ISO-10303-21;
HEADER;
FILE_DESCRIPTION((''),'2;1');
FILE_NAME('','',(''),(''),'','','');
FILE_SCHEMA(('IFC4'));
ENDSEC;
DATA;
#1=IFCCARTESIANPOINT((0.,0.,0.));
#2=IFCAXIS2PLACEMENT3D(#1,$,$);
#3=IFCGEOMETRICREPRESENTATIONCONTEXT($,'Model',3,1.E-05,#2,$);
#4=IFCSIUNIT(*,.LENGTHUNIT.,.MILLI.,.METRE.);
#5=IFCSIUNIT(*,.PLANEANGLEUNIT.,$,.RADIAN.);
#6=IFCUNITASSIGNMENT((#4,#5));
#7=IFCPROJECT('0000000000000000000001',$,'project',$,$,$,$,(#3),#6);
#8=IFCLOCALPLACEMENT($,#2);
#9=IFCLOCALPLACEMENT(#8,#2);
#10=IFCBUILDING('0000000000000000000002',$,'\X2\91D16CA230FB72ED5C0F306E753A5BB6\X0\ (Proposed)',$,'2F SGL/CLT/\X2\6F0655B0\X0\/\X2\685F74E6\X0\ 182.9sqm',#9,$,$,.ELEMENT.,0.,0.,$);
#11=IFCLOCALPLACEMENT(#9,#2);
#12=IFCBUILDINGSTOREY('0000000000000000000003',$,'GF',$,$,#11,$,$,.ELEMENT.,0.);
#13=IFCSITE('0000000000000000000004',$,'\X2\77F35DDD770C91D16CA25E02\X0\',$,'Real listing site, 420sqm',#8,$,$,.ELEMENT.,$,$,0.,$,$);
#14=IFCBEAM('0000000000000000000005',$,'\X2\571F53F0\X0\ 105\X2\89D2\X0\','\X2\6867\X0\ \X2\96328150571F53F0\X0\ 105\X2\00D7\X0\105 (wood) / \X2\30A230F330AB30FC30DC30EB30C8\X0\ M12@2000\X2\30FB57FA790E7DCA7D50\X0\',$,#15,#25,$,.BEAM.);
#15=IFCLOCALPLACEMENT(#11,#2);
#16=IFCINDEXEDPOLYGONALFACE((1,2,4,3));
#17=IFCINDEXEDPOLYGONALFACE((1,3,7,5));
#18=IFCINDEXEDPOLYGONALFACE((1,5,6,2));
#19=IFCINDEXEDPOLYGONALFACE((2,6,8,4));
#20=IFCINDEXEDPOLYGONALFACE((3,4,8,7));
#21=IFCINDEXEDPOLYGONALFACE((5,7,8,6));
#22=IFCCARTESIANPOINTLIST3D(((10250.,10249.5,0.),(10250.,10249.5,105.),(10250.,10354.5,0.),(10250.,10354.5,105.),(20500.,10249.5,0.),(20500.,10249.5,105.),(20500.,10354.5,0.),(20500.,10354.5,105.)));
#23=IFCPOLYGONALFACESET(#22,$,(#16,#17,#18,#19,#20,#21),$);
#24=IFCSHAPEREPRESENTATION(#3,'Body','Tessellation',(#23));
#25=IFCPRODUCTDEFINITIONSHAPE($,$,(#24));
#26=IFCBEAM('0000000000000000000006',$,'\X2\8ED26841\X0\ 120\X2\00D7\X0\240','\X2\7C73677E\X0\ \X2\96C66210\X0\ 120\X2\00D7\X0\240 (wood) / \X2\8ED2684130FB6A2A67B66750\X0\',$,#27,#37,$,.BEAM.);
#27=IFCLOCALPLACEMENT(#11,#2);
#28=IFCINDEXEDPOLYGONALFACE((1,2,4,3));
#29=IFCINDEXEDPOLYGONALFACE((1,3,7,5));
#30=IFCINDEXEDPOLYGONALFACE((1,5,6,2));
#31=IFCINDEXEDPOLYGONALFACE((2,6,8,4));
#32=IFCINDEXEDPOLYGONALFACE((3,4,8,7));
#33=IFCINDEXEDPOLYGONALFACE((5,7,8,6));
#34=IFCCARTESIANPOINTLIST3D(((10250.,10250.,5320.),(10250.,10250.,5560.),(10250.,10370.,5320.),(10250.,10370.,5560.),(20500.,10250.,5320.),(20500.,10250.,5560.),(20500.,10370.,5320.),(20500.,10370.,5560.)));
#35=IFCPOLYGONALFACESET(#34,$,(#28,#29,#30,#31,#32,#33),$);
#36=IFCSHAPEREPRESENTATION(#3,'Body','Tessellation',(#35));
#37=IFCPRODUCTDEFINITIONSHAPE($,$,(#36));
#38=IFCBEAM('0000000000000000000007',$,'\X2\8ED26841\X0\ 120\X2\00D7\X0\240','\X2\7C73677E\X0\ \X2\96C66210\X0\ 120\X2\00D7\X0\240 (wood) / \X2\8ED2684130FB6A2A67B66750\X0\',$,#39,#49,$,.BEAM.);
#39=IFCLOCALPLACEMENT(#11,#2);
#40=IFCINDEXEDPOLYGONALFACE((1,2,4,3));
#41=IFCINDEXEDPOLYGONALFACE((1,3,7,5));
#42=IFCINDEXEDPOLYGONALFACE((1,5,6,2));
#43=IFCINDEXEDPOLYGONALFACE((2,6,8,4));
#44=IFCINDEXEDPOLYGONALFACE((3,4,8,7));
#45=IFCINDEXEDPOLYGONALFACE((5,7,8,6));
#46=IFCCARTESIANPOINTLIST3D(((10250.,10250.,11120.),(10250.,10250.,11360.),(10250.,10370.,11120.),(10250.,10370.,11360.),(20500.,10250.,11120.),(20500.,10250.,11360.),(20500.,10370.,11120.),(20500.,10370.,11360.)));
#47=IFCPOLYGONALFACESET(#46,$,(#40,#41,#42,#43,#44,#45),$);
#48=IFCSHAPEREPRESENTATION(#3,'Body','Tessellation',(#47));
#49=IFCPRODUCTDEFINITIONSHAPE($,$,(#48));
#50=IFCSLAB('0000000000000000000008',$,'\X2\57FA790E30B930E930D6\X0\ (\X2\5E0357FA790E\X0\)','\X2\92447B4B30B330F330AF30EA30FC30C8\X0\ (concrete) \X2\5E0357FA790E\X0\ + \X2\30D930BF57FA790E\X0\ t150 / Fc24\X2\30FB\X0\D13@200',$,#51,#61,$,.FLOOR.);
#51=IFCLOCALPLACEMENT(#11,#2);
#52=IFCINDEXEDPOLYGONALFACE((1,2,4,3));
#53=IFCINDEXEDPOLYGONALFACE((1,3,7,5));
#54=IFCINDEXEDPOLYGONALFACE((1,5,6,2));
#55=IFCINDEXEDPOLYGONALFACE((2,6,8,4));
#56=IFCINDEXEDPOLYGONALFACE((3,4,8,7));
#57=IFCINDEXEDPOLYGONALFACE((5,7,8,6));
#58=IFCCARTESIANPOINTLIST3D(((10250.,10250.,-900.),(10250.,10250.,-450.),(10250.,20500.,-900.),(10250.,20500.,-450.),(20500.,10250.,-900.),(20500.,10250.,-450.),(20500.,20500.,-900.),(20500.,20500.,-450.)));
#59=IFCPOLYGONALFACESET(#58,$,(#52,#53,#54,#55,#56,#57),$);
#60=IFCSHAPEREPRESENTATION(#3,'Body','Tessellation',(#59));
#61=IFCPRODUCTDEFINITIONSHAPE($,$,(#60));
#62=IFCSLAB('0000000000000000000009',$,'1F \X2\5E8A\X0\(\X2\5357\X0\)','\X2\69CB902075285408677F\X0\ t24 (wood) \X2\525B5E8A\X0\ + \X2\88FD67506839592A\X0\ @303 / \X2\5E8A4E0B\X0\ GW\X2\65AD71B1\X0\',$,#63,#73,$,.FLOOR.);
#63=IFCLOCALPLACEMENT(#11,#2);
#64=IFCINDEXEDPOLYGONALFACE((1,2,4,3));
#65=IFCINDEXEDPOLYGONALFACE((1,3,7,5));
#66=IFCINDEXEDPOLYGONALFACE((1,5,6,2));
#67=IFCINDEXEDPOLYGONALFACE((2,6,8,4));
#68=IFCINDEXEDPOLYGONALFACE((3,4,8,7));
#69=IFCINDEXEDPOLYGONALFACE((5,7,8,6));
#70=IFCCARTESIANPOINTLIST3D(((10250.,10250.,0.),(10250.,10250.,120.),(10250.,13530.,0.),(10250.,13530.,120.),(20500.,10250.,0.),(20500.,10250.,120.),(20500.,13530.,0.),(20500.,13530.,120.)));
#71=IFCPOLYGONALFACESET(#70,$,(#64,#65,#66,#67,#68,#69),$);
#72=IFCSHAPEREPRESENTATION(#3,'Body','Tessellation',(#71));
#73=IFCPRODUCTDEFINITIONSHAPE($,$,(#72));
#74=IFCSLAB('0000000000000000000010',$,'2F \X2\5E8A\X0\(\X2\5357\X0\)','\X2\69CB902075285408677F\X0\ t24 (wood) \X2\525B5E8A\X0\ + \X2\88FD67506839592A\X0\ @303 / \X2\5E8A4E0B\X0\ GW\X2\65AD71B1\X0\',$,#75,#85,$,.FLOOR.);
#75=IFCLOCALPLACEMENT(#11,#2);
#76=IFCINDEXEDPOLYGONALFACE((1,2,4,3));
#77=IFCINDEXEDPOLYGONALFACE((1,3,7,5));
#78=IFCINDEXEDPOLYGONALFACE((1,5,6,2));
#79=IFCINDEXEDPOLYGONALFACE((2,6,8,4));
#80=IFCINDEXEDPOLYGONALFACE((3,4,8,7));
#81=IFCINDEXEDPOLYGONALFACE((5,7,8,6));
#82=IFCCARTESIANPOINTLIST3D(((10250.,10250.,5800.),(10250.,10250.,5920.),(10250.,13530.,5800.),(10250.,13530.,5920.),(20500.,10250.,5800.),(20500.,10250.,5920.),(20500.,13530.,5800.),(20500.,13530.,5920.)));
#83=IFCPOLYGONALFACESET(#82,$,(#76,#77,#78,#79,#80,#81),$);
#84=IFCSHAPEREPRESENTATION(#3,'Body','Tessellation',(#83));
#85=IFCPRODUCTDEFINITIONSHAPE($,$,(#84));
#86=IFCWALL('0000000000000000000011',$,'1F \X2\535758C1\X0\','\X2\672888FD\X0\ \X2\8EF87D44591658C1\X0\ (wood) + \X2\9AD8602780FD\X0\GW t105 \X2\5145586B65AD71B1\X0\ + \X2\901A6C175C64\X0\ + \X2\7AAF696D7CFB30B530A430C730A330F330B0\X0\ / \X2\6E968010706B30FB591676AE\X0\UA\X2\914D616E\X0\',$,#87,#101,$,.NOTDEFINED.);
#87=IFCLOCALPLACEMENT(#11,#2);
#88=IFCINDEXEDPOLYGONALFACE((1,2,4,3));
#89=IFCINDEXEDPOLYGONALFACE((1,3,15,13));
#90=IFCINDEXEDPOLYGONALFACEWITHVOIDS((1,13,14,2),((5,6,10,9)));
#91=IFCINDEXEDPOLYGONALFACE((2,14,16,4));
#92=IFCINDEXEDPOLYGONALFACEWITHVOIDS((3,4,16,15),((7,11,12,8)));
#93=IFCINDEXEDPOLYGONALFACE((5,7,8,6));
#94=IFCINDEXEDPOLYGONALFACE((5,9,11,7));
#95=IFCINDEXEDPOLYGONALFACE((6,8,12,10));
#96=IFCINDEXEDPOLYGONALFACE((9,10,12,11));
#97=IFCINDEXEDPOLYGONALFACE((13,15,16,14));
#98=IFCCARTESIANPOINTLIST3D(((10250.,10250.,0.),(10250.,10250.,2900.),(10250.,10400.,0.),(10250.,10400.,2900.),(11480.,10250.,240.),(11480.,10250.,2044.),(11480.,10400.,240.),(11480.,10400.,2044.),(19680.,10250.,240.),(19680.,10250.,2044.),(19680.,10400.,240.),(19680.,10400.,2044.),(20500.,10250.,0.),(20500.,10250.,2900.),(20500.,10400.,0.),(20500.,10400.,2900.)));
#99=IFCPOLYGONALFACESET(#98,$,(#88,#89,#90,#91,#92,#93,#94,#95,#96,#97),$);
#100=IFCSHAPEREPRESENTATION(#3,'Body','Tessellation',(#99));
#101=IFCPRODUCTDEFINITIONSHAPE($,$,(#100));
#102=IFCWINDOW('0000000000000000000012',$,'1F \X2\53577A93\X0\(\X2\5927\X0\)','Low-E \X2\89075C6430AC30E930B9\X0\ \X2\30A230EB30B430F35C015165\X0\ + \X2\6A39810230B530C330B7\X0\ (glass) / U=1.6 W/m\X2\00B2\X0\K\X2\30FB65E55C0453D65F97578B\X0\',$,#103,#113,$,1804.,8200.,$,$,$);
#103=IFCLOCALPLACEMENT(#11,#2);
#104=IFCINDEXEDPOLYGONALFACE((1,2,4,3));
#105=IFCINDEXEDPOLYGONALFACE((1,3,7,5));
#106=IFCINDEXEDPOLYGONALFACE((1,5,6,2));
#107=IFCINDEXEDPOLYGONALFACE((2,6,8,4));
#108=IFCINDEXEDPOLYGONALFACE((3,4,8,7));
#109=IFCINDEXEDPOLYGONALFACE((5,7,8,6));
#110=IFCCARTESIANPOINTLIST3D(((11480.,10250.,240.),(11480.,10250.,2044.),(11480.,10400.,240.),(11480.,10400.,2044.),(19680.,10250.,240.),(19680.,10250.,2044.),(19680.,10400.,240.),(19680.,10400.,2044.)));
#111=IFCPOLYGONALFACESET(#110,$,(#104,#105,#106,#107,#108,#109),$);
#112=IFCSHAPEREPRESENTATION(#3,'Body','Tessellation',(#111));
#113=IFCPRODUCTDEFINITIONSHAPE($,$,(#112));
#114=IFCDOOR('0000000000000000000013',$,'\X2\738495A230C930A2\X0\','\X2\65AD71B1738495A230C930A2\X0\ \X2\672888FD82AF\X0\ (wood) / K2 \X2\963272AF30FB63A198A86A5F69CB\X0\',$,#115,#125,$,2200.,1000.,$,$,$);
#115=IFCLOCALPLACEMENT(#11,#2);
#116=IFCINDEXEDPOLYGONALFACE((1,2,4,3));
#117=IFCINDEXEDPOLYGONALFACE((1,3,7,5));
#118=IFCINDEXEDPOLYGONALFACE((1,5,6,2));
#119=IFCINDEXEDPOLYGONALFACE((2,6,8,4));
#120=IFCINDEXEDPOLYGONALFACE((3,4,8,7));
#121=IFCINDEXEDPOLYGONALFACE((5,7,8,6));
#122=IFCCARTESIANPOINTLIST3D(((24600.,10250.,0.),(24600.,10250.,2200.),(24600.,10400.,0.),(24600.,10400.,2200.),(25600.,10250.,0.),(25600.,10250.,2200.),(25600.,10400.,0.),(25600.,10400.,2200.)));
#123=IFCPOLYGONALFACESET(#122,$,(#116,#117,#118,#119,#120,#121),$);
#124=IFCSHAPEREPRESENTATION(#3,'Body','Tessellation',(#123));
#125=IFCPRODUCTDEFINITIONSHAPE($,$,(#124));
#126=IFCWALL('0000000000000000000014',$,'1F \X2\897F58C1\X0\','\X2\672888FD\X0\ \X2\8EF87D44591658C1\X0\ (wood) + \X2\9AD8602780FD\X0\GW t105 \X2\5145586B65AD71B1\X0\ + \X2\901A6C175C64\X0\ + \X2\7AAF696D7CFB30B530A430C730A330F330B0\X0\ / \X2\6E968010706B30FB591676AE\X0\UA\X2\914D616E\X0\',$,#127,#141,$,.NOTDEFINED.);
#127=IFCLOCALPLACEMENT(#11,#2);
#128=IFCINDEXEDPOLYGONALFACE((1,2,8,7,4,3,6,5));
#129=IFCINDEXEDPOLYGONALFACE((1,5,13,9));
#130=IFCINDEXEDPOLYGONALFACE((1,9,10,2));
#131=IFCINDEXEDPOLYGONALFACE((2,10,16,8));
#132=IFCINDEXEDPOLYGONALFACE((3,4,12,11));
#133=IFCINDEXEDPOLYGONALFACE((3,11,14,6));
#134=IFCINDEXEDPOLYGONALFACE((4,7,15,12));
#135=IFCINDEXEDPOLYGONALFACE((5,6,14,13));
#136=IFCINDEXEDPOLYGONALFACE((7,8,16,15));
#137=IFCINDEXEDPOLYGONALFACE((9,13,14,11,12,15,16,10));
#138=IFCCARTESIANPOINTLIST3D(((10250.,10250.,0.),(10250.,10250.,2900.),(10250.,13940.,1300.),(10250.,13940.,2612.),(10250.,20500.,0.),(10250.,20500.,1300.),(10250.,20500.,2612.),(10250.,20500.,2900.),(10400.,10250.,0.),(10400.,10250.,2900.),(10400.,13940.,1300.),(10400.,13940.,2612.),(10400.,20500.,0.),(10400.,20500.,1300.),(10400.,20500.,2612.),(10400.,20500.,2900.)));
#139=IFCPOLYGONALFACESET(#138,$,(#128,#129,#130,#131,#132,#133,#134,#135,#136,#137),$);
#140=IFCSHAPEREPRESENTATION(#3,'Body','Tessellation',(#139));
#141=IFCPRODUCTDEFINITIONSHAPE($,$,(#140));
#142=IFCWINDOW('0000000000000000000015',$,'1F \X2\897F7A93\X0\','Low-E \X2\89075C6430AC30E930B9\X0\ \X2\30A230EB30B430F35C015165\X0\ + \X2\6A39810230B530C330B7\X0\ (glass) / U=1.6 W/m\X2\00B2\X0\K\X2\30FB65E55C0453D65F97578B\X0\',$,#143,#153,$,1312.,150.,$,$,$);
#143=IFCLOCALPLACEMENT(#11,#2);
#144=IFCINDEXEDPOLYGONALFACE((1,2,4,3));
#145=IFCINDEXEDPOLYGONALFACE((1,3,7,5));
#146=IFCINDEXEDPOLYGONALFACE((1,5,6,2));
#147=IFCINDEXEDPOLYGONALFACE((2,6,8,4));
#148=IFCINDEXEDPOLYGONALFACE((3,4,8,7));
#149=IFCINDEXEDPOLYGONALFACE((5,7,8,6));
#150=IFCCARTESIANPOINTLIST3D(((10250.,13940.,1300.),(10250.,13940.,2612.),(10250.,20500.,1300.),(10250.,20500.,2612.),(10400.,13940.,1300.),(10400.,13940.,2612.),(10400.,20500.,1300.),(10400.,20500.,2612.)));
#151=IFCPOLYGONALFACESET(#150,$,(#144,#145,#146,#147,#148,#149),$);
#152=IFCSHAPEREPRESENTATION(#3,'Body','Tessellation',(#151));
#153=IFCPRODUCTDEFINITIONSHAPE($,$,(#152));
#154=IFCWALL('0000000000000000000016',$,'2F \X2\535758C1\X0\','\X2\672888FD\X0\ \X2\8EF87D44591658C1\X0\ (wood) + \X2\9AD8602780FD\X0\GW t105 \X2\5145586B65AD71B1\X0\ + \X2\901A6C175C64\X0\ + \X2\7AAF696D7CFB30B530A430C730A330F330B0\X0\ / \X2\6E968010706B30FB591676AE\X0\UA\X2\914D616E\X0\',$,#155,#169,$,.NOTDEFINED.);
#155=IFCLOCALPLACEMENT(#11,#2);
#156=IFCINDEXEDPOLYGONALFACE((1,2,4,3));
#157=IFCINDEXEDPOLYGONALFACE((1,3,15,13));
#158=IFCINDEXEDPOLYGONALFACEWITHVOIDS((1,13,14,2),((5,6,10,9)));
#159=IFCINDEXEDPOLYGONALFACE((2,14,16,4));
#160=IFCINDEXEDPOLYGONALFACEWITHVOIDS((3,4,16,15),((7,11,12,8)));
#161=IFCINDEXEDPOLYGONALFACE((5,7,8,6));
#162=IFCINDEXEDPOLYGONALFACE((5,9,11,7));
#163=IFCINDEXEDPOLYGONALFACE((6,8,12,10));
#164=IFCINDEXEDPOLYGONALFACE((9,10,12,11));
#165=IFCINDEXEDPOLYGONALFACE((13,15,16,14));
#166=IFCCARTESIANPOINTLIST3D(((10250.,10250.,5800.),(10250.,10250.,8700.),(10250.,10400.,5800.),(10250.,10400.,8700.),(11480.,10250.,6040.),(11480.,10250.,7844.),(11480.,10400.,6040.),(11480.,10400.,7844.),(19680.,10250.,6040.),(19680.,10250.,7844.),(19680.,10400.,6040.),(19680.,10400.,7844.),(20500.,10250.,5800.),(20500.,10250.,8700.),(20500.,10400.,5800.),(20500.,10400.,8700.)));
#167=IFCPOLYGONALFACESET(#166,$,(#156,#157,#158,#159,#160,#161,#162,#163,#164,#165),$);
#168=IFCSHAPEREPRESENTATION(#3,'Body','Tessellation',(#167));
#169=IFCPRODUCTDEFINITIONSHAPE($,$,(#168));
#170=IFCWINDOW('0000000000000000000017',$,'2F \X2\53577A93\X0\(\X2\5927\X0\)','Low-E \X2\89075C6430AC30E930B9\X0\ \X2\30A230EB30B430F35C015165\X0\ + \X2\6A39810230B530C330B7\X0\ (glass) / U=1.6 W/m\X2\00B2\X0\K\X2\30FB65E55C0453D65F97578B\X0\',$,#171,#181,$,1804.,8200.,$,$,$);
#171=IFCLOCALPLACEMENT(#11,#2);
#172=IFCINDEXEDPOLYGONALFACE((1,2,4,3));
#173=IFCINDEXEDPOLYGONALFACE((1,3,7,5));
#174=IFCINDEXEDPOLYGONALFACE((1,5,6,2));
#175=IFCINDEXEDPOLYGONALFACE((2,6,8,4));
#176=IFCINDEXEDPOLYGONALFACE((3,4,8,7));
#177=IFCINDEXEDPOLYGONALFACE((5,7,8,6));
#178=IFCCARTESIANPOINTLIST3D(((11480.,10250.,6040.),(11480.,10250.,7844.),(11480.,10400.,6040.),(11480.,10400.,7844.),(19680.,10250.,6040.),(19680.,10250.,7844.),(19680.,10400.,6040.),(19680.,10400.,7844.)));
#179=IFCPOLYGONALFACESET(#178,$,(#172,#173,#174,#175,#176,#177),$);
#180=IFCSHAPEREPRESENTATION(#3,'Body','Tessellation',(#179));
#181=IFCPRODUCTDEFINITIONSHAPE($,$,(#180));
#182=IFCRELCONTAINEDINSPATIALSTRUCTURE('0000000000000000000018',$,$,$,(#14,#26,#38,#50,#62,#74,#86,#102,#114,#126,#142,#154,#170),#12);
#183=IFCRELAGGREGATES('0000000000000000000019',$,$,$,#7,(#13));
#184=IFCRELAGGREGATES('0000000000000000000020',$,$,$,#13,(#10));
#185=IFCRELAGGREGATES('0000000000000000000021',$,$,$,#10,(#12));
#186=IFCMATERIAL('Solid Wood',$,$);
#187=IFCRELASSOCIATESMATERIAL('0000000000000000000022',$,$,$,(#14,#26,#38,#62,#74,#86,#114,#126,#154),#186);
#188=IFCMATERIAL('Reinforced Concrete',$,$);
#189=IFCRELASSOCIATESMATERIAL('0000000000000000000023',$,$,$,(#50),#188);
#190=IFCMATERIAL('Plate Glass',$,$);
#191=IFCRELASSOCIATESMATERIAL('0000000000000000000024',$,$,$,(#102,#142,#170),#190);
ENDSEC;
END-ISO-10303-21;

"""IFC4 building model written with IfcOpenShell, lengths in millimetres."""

from ifc_helpers import new_model, si_unit, frame, frame_2d, origin, place, context, project, spatial, rectangle, extrude, material, element, fill, save


model = new_model("IFC4")

# Units and contexts
model_context = context("Model", 3, precision=1e-05, world=origin())
ifc_project = project(units=[si_unit("LENGTHUNIT", "METRE", prefix="MILLI"), si_unit("PLANEANGLEUNIT", "RADIAN")], contexts=[model_context])

# Site, building, storey
site_placement = place(None, origin())
site = spatial("IfcSite", under=ifc_project, at=site_placement, Name="石川県金沢市", ObjectType="Real listing site, 420sqm", CompositionType="ELEMENT", RefElevation=0.0)
building_placement = place(site_placement, origin())
building = spatial("IfcBuilding", under=site, at=building_placement, Name="金沢・狭小の町家 (Proposed)", ObjectType="2F SGL/CLT/漆喰/桟瓦 182.9sqm", CompositionType="ELEMENT", ElevationOfRefHeight=0.0, ElevationOfTerrain=0.0)
storey_placement = place(building_placement, origin())
storey = spatial("IfcBuildingStorey", under=building, at=storey_placement, Name="GF", CompositionType="ELEMENT", Elevation=0.0)

# Shared definitions
ifc_material_1 = material(Name="Solid Wood")

# Beams
beam_1_placement = place(storey_placement, frame((5125.0, 5125.0, 0.0)))
element("IfcBeam", 1, at=beam_1_placement, inside=storey, material=ifc_material_1, Name="土台 105角", Description="桧 防腐土台 105×105 (wood) / アンカーボルト M12@2000・基礎緊結", PredefinedType="BEAM", context=model_context, shape_type="SweptSolid", body=[
    extrude(rectangle(XDim=10250.0, YDim=105.0, at=frame_2d((5125.0, 52.0))), frame((5125.0, 5125.0, 0.0)), (0.0, 0.0, 1.0), 105.0),
])
beam_2_placement = place(storey_placement, frame((5125.0, 5125.0, 2660.0)))
element("IfcBeam", 2, at=beam_2_placement, inside=storey, material=ifc_material_1, Name="軒桁 120×240", Description="米松 集成 120×240 (wood) / 軒桁・横架材", PredefinedType="BEAM", context=model_context, shape_type="SweptSolid", body=[
    extrude(rectangle(XDim=10250.0, YDim=120.0, at=frame_2d((5125.0, 60.0))), frame((5125.0, 5125.0, 2660.0)), (0.0, 0.0, 1.0), 240.0),
])
beam_3_placement = place(storey_placement, frame((5125.0, 5125.0, 5560.0)))
element("IfcBeam", 3, at=beam_3_placement, inside=storey, material=ifc_material_1, Name="軒桁 120×240", Description="米松 集成 120×240 (wood) / 軒桁・横架材", PredefinedType="BEAM", context=model_context, shape_type="SweptSolid", body=[
    extrude(rectangle(XDim=10250.0, YDim=120.0, at=frame_2d((5125.0, 60.0))), frame((5125.0, 5125.0, 5560.0)), (0.0, 0.0, 1.0), 240.0),
])

# Slabs
ifc_material_2 = material(Name="Reinforced Concrete")
slab_1_placement = place(storey_placement, frame((5125.0, 5125.0, -450.0)))
element("IfcSlab", 4, at=slab_1_placement, inside=storey, material=ifc_material_2, Name="基礎スラブ (布基礎)", Description="鉄筋コンクリート (concrete) 布基礎 + ベタ基礎 t150 / Fc24・D13@200", PredefinedType="FLOOR", context=model_context, shape_type="SweptSolid", body=[
    extrude(rectangle(XDim=10250.0, YDim=10250.0, at=frame_2d((5125.0, 5125.0))), frame((5125.0, 5125.0, -450.0)), (0.0, 0.0, 1.0), 450.0),
])
slab_2_placement = place(storey_placement, frame((5125.0, 5125.0, 0.0)))
element("IfcSlab", 5, at=slab_2_placement, inside=storey, material=ifc_material_1, Name="1F 床(南)", Description="構造用合板 t24 (wood) 剛床 + 製材根太 @303 / 床下 GW断熱", PredefinedType="FLOOR", context=model_context, shape_type="SweptSolid", body=[
    extrude(rectangle(XDim=10250.0, YDim=3280.0, at=frame_2d((5125.0, 1640.0))), frame((5125.0, 5125.0, 0.0)), (0.0, 0.0, 1.0), 120.0),
])
slab_3_placement = place(storey_placement, frame((5125.0, 5125.0, 2900.0)))
element("IfcSlab", 6, at=slab_3_placement, inside=storey, material=ifc_material_1, Name="2F 床(南)", Description="構造用合板 t24 (wood) 剛床 + 製材根太 @303 / 床下 GW断熱", PredefinedType="FLOOR", context=model_context, shape_type="SweptSolid", body=[
    extrude(rectangle(XDim=10250.0, YDim=3280.0, at=frame_2d((5125.0, 1640.0))), frame((5125.0, 5125.0, 2900.0)), (0.0, 0.0, 1.0), 120.0),
])

# Wall, openings, window, door
wall_1_placement = place(storey_placement, frame((5125.0, 5125.0, 0.0)))
wall_1 = element("IfcWall", 7, at=wall_1_placement, inside=storey, material=ifc_material_1, Name="1F 南壁", Description="木製 軸組外壁 (wood) + 高性能GW t105 充填断熱 + 通気層 + 窯業系サイディング / 準耐火・外皮UA配慮", PredefinedType="NOTDEFINED", context=model_context, shape_type="SweptSolid", body=[
    extrude(rectangle(XDim=10250.0, YDim=150.0, at=frame_2d((5125.0, 75.0))), frame((5125.0, 5125.0, 0.0)), (0.0, 0.0, 1.0), 2900.0),
])
opening_1_placement = place(storey_placement, frame((5740.0, 5125.0, 120.0)))
opening_1 = element("IfcOpeningElement", 8, at=opening_1_placement, cuts=wall_1, PredefinedType="NOTDEFINED", context=model_context, shape_type="SweptSolid", body=[
    extrude(rectangle(XDim=8200.0, YDim=150.0, at=frame_2d((4100.0, 75.0))), frame((5740.0, 5125.0, 120.0)), (0.0, 0.0, 1.0), 1804.0),
])
opening_2_placement = place(storey_placement, frame((12300.0, 5125.0, 0.0)))
opening_2 = element("IfcOpeningElement", 9, at=opening_2_placement, cuts=wall_1, PredefinedType="NOTDEFINED", context=model_context, shape_type="SweptSolid", body=[
    extrude(rectangle(XDim=1000.0, YDim=150.0, at=frame_2d((500.0, 75.0))), frame((12300.0, 5125.0, 0.0)), (0.0, 0.0, 1.0), 2200.0),
])
ifc_material_3 = material(Name="Plate Glass")
window_1_placement = place(storey_placement, frame((5740.0, 5125.0, 120.0)))
window_1 = element("IfcWindow", 10, at=window_1_placement, inside=storey, material=ifc_material_3, Name="1F 南窓(大)", Description="Low-E 複層ガラス アルゴン封入 + 樹脂サッシ (glass) / U=1.6 W/m²K・日射取得型", OverallHeight=1804.0, OverallWidth=8200.0, context=model_context, shape_type="SweptSolid", body=[
    extrude(rectangle(XDim=8200.0, YDim=150.0, at=frame_2d((4100.0, 75.0))), frame((5740.0, 5125.0, 120.0)), (0.0, 0.0, 1.0), 1804.0),
])
fill(opening_1, window_1)
door_placement = place(storey_placement, frame((12300.0, 5125.0, 0.0)))
door = element("IfcDoor", 11, at=door_placement, inside=storey, material=ifc_material_1, Name="玄関ドア", Description="断熱玄関ドア 木製芯 (wood) / K2 防犯・採風機構", OverallHeight=2200.0, OverallWidth=1000.0, context=model_context, shape_type="SweptSolid", body=[
    extrude(rectangle(XDim=1000.0, YDim=150.0, at=frame_2d((500.0, 75.0))), frame((12300.0, 5125.0, 0.0)), (0.0, 0.0, 1.0), 2200.0),
])
fill(opening_2, door)

# Walls, openings, windows
wall_2_placement = place(storey_placement, frame((5125.0, 5125.0, 0.0)))
wall_2 = element("IfcWall", 12, at=wall_2_placement, inside=storey, material=ifc_material_1, Name="1F 西壁", Description="木製 軸組外壁 (wood) + 高性能GW t105 充填断熱 + 通気層 + 窯業系サイディング / 準耐火・外皮UA配慮", PredefinedType="NOTDEFINED", context=model_context, shape_type="SweptSolid", body=[
    extrude(rectangle(XDim=150.0, YDim=10250.0, at=frame_2d((75.0, 5125.0))), frame((5125.0, 5125.0, 0.0)), (0.0, 0.0, 1.0), 2900.0),
])
opening_3_placement = place(storey_placement, frame((5125.0, 6970.0, 650.0)))
opening_3 = element("IfcOpeningElement", 13, at=opening_3_placement, cuts=wall_2, PredefinedType="NOTDEFINED", context=model_context, shape_type="SweptSolid", body=[
    extrude(rectangle(XDim=150.0, YDim=6560.0, at=frame_2d((75.0, 3280.0))), frame((5125.0, 6970.0, 650.0)), (0.0, 0.0, 1.0), 1312.0),
])
window_2_placement = place(storey_placement, frame((5125.0, 6970.0, 650.0)))
window_2 = element("IfcWindow", 14, at=window_2_placement, inside=storey, material=ifc_material_3, Name="1F 西窓", Description="Low-E 複層ガラス アルゴン封入 + 樹脂サッシ (glass) / U=1.6 W/m²K・日射取得型", OverallHeight=1312.0, OverallWidth=150.0, context=model_context, shape_type="SweptSolid", body=[
    extrude(rectangle(XDim=150.0, YDim=6560.0, at=frame_2d((75.0, 3280.0))), frame((5125.0, 6970.0, 650.0)), (0.0, 0.0, 1.0), 1312.0),
])
fill(opening_3, window_2)
wall_3_placement = place(storey_placement, frame((5125.0, 5125.0, 2900.0)))
wall_3 = element("IfcWall", 15, at=wall_3_placement, inside=storey, material=ifc_material_1, Name="2F 南壁", Description="木製 軸組外壁 (wood) + 高性能GW t105 充填断熱 + 通気層 + 窯業系サイディング / 準耐火・外皮UA配慮", PredefinedType="NOTDEFINED", context=model_context, shape_type="SweptSolid", body=[
    extrude(rectangle(XDim=10250.0, YDim=150.0, at=frame_2d((5125.0, 75.0))), frame((5125.0, 5125.0, 2900.0)), (0.0, 0.0, 1.0), 2900.0),
])
opening_4_placement = place(storey_placement, frame((5740.0, 5125.0, 3020.0)))
opening_4 = element("IfcOpeningElement", 16, at=opening_4_placement, cuts=wall_3, PredefinedType="NOTDEFINED", context=model_context, shape_type="SweptSolid", body=[
    extrude(rectangle(XDim=8200.0, YDim=150.0, at=frame_2d((4100.0, 75.0))), frame((5740.0, 5125.0, 3020.0)), (0.0, 0.0, 1.0), 1804.0),
])
window_3_placement = place(storey_placement, frame((5740.0, 5125.0, 3020.0)))
window_3 = element("IfcWindow", 17, at=window_3_placement, inside=storey, material=ifc_material_3, Name="2F 南窓(大)", Description="Low-E 複層ガラス アルゴン封入 + 樹脂サッシ (glass) / U=1.6 W/m²K・日射取得型", OverallHeight=1804.0, OverallWidth=8200.0, context=model_context, shape_type="SweptSolid", body=[
    extrude(rectangle(XDim=8200.0, YDim=150.0, at=frame_2d((4100.0, 75.0))), frame((5740.0, 5125.0, 3020.0)), (0.0, 0.0, 1.0), 1804.0),
])
fill(opening_4, window_3)

save(model, "model.ifc")
